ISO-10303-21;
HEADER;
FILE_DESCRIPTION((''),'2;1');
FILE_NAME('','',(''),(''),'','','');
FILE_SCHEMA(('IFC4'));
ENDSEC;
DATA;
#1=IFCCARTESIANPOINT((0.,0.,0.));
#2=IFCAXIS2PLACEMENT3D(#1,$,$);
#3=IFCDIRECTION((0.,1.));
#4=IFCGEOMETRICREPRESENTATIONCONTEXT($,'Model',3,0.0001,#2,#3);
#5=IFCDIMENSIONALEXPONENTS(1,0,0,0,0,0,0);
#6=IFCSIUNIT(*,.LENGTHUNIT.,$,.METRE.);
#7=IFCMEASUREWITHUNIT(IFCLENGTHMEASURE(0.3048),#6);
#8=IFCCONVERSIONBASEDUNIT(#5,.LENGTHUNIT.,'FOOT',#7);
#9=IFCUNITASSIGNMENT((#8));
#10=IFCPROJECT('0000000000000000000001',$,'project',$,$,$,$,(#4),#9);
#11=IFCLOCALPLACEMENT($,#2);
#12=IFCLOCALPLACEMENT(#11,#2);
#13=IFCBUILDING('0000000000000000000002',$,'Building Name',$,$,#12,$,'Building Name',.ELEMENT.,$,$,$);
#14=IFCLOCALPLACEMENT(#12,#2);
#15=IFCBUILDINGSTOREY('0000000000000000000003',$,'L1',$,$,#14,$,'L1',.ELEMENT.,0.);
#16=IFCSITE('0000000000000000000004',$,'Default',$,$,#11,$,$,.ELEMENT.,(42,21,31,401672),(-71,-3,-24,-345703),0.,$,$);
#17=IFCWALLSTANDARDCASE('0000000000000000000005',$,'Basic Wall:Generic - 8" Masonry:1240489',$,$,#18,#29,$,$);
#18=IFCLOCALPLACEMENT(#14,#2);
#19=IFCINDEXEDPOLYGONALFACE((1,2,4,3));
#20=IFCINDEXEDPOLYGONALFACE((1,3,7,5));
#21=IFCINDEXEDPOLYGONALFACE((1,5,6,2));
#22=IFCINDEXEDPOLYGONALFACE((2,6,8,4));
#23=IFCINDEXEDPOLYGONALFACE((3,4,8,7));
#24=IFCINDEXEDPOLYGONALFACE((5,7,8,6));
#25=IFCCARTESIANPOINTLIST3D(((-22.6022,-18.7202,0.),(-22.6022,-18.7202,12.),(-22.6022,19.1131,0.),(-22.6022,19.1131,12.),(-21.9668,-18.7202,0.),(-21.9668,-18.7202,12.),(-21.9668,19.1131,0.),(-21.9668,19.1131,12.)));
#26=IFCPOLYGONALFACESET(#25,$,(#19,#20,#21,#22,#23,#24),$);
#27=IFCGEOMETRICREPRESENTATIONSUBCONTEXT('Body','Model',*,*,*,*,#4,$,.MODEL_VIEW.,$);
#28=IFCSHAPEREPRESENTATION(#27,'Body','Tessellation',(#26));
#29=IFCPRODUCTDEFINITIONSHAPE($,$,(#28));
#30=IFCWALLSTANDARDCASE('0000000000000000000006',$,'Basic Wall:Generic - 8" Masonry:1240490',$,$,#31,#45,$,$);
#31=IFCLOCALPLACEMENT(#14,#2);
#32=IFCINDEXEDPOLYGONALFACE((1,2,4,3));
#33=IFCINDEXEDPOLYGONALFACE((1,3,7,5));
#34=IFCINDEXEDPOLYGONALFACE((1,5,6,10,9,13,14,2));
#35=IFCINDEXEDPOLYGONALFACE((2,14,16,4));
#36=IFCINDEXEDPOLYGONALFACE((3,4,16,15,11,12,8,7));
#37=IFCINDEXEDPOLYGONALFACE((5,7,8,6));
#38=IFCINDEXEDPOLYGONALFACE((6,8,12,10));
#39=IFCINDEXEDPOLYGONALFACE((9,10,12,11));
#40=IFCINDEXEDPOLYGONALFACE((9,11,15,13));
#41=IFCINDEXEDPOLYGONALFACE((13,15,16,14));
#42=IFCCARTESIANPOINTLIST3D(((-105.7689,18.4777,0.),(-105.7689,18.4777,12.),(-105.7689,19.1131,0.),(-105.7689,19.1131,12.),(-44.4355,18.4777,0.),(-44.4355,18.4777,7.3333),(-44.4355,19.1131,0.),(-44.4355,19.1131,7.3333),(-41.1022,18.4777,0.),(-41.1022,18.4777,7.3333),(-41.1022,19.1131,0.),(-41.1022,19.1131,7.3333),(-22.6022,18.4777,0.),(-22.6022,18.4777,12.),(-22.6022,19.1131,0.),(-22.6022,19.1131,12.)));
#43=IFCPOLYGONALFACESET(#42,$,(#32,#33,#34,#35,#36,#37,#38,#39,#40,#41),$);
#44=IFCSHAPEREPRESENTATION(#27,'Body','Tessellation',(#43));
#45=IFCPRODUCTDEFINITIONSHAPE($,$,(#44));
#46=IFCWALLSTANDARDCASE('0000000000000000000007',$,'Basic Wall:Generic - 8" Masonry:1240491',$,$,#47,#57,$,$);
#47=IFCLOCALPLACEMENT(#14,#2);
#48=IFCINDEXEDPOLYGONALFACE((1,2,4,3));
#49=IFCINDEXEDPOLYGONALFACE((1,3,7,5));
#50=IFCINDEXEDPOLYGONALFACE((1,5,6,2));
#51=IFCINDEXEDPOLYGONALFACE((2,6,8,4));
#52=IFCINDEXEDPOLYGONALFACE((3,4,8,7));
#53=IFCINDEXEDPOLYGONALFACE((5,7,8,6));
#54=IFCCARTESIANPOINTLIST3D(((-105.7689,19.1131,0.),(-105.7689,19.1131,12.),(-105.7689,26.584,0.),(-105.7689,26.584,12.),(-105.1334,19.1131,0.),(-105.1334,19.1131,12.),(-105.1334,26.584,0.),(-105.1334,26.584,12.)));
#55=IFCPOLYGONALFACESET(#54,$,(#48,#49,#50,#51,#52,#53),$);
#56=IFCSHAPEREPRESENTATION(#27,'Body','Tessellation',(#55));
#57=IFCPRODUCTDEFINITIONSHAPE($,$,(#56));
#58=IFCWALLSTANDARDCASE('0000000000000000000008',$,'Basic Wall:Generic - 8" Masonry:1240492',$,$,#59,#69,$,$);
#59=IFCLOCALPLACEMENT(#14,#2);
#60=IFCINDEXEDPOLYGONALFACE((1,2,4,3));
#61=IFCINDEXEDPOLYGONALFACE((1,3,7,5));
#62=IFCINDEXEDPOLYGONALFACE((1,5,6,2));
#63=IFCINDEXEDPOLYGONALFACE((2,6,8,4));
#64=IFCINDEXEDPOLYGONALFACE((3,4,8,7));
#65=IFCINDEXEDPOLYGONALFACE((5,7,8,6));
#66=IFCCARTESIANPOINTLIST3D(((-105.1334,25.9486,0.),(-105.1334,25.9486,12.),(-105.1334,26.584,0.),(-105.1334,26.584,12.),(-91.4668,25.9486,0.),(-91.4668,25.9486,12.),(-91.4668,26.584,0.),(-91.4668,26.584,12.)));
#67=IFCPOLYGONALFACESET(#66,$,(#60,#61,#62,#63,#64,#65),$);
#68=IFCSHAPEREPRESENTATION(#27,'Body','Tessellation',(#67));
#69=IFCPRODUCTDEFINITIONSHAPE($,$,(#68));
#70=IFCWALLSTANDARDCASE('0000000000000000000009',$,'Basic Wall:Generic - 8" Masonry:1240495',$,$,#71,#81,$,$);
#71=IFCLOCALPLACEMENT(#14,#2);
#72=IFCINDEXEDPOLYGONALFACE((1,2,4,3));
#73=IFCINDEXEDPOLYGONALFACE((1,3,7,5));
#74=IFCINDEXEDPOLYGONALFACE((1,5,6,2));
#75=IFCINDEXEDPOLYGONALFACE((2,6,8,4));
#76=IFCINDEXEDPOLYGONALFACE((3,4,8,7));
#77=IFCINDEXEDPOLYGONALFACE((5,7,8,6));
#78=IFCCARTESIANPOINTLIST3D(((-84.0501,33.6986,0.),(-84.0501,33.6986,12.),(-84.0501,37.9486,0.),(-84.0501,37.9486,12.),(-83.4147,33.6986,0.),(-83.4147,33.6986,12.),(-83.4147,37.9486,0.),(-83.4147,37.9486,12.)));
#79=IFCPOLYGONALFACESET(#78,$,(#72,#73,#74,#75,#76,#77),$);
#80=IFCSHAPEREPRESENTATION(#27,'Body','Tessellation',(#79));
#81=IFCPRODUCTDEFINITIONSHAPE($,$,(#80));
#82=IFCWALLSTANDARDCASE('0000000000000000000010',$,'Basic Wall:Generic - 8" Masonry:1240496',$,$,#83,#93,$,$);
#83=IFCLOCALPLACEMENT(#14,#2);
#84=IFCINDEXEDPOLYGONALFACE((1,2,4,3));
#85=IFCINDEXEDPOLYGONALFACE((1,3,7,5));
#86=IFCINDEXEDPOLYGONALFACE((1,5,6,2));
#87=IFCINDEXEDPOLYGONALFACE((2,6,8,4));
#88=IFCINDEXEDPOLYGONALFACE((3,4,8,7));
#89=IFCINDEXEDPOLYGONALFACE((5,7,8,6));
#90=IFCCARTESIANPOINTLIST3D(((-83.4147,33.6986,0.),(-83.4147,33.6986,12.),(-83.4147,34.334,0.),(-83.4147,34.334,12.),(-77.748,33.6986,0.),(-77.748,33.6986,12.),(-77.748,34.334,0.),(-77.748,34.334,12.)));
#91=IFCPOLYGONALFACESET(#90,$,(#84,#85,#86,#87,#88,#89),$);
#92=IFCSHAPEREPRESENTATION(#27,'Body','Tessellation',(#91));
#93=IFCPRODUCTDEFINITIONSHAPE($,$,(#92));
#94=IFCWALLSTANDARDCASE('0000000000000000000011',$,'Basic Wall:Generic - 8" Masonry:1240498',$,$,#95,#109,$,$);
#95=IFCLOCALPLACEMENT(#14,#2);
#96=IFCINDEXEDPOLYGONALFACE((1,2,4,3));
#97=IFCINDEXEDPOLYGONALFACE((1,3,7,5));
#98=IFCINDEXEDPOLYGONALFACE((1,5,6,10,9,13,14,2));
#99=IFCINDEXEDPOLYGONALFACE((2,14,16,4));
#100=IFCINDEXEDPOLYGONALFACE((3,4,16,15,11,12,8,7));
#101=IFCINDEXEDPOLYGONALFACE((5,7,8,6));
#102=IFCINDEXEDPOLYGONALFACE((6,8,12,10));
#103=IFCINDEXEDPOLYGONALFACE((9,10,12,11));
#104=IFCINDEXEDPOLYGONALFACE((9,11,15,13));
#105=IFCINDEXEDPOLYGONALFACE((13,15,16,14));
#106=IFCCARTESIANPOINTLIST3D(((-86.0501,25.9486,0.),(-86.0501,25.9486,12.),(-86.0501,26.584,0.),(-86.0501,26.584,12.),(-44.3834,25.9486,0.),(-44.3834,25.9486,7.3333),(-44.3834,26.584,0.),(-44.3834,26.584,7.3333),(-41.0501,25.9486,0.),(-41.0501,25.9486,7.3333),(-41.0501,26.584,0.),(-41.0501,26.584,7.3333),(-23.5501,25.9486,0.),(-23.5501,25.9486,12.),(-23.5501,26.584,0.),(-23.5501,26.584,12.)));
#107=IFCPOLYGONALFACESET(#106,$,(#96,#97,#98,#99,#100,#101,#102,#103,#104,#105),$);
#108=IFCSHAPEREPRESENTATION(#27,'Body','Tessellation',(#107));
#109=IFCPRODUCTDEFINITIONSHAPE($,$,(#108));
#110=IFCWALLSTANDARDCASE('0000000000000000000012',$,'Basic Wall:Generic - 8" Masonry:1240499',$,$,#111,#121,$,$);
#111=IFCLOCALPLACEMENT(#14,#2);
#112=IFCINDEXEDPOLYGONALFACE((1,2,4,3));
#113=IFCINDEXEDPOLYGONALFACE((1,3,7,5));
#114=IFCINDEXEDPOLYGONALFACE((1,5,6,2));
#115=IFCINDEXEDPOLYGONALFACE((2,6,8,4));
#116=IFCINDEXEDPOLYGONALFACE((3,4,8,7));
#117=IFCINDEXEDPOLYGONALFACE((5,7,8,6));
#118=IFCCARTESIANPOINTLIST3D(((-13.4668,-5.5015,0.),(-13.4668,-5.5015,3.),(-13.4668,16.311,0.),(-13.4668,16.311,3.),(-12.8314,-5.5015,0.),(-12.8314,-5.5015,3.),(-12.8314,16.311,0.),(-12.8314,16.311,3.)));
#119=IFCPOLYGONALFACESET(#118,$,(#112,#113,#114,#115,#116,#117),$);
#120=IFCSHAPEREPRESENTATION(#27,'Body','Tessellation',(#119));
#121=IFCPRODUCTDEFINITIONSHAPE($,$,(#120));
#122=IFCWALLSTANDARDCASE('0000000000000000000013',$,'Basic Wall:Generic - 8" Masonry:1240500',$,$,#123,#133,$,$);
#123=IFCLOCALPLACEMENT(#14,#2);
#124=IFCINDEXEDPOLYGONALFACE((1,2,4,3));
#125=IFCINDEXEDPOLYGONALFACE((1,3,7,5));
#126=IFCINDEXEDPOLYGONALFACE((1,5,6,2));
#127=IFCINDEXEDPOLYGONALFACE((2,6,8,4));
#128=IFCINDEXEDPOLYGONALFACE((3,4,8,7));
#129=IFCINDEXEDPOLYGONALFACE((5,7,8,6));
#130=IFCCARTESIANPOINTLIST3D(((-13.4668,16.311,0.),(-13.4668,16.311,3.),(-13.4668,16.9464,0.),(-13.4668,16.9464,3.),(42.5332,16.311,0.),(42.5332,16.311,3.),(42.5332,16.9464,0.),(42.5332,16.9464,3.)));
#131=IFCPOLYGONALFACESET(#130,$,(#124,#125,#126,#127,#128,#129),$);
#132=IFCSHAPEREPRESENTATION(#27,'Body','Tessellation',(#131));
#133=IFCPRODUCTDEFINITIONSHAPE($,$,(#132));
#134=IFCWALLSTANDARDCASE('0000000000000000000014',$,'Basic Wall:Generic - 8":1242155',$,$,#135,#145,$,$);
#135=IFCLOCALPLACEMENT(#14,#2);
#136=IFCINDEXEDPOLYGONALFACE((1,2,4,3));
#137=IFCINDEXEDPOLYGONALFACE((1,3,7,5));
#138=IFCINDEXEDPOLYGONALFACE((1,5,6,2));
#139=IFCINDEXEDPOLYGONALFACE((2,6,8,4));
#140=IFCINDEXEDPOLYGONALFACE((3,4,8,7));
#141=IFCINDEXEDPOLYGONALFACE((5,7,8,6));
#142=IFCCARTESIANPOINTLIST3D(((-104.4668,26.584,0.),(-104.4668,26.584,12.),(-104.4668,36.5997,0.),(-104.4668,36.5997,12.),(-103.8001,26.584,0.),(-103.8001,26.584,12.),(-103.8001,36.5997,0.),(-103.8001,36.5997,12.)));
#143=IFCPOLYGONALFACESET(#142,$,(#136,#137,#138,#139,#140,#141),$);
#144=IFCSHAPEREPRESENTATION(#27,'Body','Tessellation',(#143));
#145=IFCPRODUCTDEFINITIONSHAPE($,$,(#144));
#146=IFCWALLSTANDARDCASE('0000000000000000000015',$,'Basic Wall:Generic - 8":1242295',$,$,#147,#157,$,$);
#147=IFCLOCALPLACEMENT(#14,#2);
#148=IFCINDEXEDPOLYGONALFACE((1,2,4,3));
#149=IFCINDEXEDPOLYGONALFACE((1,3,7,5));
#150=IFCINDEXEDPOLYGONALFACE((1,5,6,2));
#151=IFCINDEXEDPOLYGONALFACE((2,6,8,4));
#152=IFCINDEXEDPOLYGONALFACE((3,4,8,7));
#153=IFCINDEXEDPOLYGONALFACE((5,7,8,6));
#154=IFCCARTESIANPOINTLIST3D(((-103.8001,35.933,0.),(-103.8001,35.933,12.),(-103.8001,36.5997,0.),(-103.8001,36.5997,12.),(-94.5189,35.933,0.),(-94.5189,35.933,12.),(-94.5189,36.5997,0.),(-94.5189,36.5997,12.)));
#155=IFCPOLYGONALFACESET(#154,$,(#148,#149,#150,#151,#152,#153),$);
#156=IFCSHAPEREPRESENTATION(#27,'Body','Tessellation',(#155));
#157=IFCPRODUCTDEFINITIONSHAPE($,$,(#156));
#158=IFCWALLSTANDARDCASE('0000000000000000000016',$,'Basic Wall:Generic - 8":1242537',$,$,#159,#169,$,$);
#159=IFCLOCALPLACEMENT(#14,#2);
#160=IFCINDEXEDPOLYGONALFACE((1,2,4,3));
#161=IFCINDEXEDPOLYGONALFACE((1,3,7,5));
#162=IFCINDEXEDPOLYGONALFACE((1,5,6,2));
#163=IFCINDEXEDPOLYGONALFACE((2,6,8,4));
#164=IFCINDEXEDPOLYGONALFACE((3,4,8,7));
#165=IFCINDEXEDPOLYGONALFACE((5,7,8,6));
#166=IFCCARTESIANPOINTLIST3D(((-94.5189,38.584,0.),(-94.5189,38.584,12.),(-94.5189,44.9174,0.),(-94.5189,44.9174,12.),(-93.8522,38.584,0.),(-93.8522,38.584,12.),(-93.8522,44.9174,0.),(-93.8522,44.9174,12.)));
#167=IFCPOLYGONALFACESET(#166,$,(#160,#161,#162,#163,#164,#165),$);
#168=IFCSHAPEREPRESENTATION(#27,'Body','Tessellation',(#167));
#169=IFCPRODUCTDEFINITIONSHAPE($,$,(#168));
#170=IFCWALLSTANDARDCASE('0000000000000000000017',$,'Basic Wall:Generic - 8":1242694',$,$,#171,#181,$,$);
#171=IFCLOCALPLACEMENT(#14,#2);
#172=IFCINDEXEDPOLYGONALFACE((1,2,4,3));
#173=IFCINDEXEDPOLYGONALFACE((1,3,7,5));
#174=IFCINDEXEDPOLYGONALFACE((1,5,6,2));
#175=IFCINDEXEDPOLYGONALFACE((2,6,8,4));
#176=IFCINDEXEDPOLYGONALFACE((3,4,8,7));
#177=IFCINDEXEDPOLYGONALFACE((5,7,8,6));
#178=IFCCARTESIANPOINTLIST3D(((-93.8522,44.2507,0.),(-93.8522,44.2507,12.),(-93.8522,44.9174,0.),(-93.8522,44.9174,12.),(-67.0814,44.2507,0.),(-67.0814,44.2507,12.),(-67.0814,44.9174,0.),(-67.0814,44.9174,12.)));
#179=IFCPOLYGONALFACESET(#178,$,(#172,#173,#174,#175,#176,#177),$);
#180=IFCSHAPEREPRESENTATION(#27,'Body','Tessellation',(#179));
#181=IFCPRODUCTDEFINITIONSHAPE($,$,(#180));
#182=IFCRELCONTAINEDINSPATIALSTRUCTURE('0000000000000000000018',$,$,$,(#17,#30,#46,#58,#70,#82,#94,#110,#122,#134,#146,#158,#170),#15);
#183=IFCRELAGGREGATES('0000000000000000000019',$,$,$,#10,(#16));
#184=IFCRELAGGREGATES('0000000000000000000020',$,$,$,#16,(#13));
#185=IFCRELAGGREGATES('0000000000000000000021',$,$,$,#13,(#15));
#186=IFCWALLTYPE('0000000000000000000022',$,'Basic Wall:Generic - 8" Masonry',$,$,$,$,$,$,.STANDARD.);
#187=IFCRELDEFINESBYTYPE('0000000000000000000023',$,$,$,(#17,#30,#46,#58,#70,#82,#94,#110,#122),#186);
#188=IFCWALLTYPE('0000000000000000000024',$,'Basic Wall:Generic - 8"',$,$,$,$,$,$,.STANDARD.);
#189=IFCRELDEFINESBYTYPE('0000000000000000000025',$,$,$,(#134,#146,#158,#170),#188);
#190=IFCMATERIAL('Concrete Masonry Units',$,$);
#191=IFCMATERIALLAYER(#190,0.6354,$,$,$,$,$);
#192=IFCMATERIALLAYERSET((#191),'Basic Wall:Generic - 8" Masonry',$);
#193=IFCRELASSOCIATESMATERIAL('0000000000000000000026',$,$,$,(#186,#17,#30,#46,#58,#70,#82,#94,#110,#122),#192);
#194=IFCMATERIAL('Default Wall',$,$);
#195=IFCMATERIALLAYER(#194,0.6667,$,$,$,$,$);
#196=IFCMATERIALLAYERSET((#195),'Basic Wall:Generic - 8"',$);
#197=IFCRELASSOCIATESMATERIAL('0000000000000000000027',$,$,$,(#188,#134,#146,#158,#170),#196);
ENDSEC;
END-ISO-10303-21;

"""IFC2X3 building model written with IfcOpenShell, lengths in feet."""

from ifc_helpers import new_model, entity, si_unit, converted_unit, direction, frame, frame_2d, origin, place, context, subcontext, project, spatial, rectangle, extrude, material, layer, layer_set, layer_usage, type_object, element, save


model = new_model("IFC2X3")

# Units and contexts
model_context = context("Model", 3, precision=0.0001, world=origin(), true_north=direction((0.0, 1.0)))
body_context = subcontext(model_context, "Body", "Model", "MODEL_VIEW")
ifc_project = project(units=[converted_unit("LENGTHUNIT", "FOOT", entity("IfcLengthMeasure", 0.3048), si_unit("LENGTHUNIT", "METRE"), dimensions=[1, 0, 0, 0, 0, 0, 0])], contexts=[model_context])

# Site, building, storey
site_placement = place(None, origin())
site = spatial("IfcSite", under=ifc_project, at=site_placement, Name="Default", CompositionType="ELEMENT", RefLatitude=(42, 21, 31, 401672), RefLongitude=(-71, -3, -24, -345703), RefElevation=0.0)
building_placement = place(site_placement, origin())
building = spatial("IfcBuilding", under=site, at=building_placement, Name="Building Name", LongName="Building Name", CompositionType="ELEMENT")
storey_placement = place(building_placement, origin())
storey = spatial("IfcBuildingStorey", under=building, at=storey_placement, Name="L1", LongName="L1", CompositionType="ELEMENT", Elevation=0.0)

# Wall
ifc_material_1 = material(Name="Concrete Masonry Units")
ifc_layer_1 = layer(ifc_material_1, 0.6354)
ifc_layer_set_1 = layer_set([ifc_layer_1], Name="Basic Wall:Generic - 8\" Masonry")
ifc_layer_usage_1 = layer_usage(ifc_layer_set_1, "AXIS2", "NEGATIVE", 0.3177)
wall_type_1 = type_object("IfcWallType", Name="Basic Wall:Generic - 8\" Masonry", PredefinedType="STANDARD", material=ifc_layer_set_1)
wall_1_placement = place(storey_placement, frame((-22.2845, 19.1131, 0.0), z_axis=(0.0, 0.0, 1.0), x_axis=(0.0, -1.0, 0.0)))
element("IfcWallStandardCase", 1, at=wall_1_placement, inside=storey, type_object=wall_type_1, material=ifc_layer_usage_1, Name="Basic Wall:Generic - 8\" Masonry:1240489", context=body_context, shape_type="SweptSolid", body=[
    extrude(rectangle(XDim=37.8333, YDim=0.6354, at=frame_2d((18.9167, 0.0), x_axis=(-1.0, 0.0))), origin(), (0.0, 0.0, 1.0), 12.0),
])

# Wall, opening
ifc_layer_usage_2 = layer_usage(ifc_layer_set_1, "AXIS2", "NEGATIVE", 0.3177)
wall_2_placement = place(storey_placement, frame((-22.6022, 18.7954, 0.0), z_axis=(0.0, 0.0, 1.0), x_axis=(-1.0, 0.0, 0.0)))
wall_2 = element("IfcWallStandardCase", 2, at=wall_2_placement, inside=storey, type_object=wall_type_1, material=ifc_layer_usage_2, Name="Basic Wall:Generic - 8\" Masonry:1240490", context=body_context, shape_type="SweptSolid", body=[
    extrude(rectangle(XDim=83.1667, YDim=0.6354, at=frame_2d((41.5833, 0.0), x_axis=(1.0, 0.0))), origin(), (0.0, 0.0, 1.0), 12.0),
])
opening_1_placement = place(wall_2_placement, frame((18.5, -0.3177, 0.0)))
element("IfcOpeningElement", 3, at=opening_1_placement, cuts=wall_2, ObjectType="Opening", context=body_context, shape_type="SweptSolid", body=[
    extrude(rectangle(XDim=7.3333, YDim=3.3333, at=frame_2d((3.6667, 1.6667), x_axis=(1.0, 0.0))), frame((0.0, 0.0, 0.0), z_axis=(0.0, 1.0, 0.0), x_axis=(0.0, 0.0, 1.0)), (0.0, 0.0, 1.0), 0.6354),
])

# Walls
ifc_layer_usage_3 = layer_usage(ifc_layer_set_1, "AXIS2", "NEGATIVE", 0.3177)
wall_3_placement = place(storey_placement, frame((-105.4511, 19.1131, 0.0), z_axis=(0.0, 0.0, 1.0), x_axis=(0.0, 1.0, 0.0)))
element("IfcWallStandardCase", 4, at=wall_3_placement, inside=storey, type_object=wall_type_1, material=ifc_layer_usage_3, Name="Basic Wall:Generic - 8\" Masonry:1240491", context=body_context, shape_type="SweptSolid", body=[
    extrude(rectangle(XDim=7.4709, YDim=0.6354, at=frame_2d((3.7355, 0.0), x_axis=(-1.0, 0.0))), origin(), (0.0, 0.0, 1.0), 12.0),
])
ifc_layer_usage_4 = layer_usage(ifc_layer_set_1, "AXIS2", "NEGATIVE", 0.3177)
wall_4_placement = place(storey_placement, frame((-105.1334, 26.2663, 0.0)))
element("IfcWallStandardCase", 5, at=wall_4_placement, inside=storey, type_object=wall_type_1, material=ifc_layer_usage_4, Name="Basic Wall:Generic - 8\" Masonry:1240492", context=body_context, shape_type="SweptSolid", body=[
    extrude(rectangle(XDim=13.6667, YDim=0.6354, at=frame_2d((6.8333, 0.0), x_axis=(-1.0, 0.0))), origin(), (0.0, 0.0, 1.0), 12.0),
])

# Walls
ifc_layer_usage_5 = layer_usage(ifc_layer_set_1, "AXIS2", "NEGATIVE", 0.3177)
wall_5_placement = place(storey_placement, frame((-83.7324, 37.9486, 0.0), z_axis=(0.0, 0.0, 1.0), x_axis=(0.0, -1.0, 0.0)))
element("IfcWallStandardCase", 6, at=wall_5_placement, inside=storey, type_object=wall_type_1, material=ifc_layer_usage_5, Name="Basic Wall:Generic - 8\" Masonry:1240495", context=body_context, shape_type="SweptSolid", body=[
    extrude(rectangle(XDim=4.25, YDim=0.6354, at=frame_2d((2.125, 0.0), x_axis=(-1.0, 0.0))), origin(), (0.0, 0.0, 1.0), 12.0),
])
ifc_layer_usage_6 = layer_usage(ifc_layer_set_1, "AXIS2", "NEGATIVE", 0.3177)
wall_6_placement = place(storey_placement, frame((-83.4147, 34.0163, 0.0)))
element("IfcWallStandardCase", 7, at=wall_6_placement, inside=storey, type_object=wall_type_1, material=ifc_layer_usage_6, Name="Basic Wall:Generic - 8\" Masonry:1240496", context=body_context, shape_type="SweptSolid", body=[
    extrude(rectangle(XDim=5.6667, YDim=0.6354, at=frame_2d((2.8333, 0.0), x_axis=(-1.0, 0.0))), origin(), (0.0, 0.0, 1.0), 12.0),
])

# Wall, opening
ifc_layer_usage_7 = layer_usage(ifc_layer_set_1, "AXIS2", "NEGATIVE", 0.3177)
wall_7_placement = place(storey_placement, frame((-23.5501, 26.2663, 0.0), z_axis=(0.0, 0.0, 1.0), x_axis=(-1.0, 0.0, 0.0)))
wall_7 = element("IfcWallStandardCase", 8, at=wall_7_placement, inside=storey, type_object=wall_type_1, material=ifc_layer_usage_7, Name="Basic Wall:Generic - 8\" Masonry:1240498", context=body_context, shape_type="SweptSolid", body=[
    extrude(rectangle(XDim=62.5, YDim=0.6354, at=frame_2d((31.25, 0.0), x_axis=(1.0, 0.0))), origin(), (0.0, 0.0, 1.0), 12.0),
])
opening_2_placement = place(wall_7_placement, frame((20.8333, 0.3177, 0.0)))
element("IfcOpeningElement", 9, at=opening_2_placement, cuts=wall_7, ObjectType="Opening", context=body_context, shape_type="SweptSolid", body=[
    extrude(rectangle(XDim=7.3333, YDim=3.3333, at=frame_2d((3.6667, 1.6667), x_axis=(1.0, 0.0))), frame((0.0, 0.0, 0.0), z_axis=(0.0, -1.0, 0.0), x_axis=(0.0, 0.0, 1.0)), (0.0, 0.0, 1.0), 0.6354),
])

# Walls
ifc_layer_usage_8 = layer_usage(ifc_layer_set_1, "AXIS2", "NEGATIVE", 0.3177)
wall_8_placement = place(storey_placement, frame((-13.1491, -5.5015, 0.0), z_axis=(0.0, 0.0, 1.0), x_axis=(0.0, 1.0, 0.0)))
element("IfcWallStandardCase", 10, at=wall_8_placement, inside=storey, type_object=wall_type_1, material=ifc_layer_usage_8, Name="Basic Wall:Generic - 8\" Masonry:1240499", context=body_context, shape_type="SweptSolid", body=[
    extrude(rectangle(XDim=21.8125, YDim=0.6354, at=frame_2d((10.9063, 0.0), x_axis=(-1.0, 0.0))), origin(), (0.0, 0.0, 1.0), 3.0),
])
ifc_layer_usage_9 = layer_usage(ifc_layer_set_1, "AXIS2", "NEGATIVE", 0.3177)
wall_9_placement = place(storey_placement, frame((-13.4668, 16.6287, 0.0)))
element("IfcWallStandardCase", 11, at=wall_9_placement, inside=storey, type_object=wall_type_1, material=ifc_layer_usage_9, Name="Basic Wall:Generic - 8\" Masonry:1240500", context=body_context, shape_type="SweptSolid", body=[
    extrude(rectangle(XDim=56.0, YDim=0.6354, at=frame_2d((28.0, 0.0), x_axis=(-1.0, 0.0))), origin(), (0.0, 0.0, 1.0), 3.0),
])
ifc_material_2 = material(Name="Default Wall")
ifc_layer_2 = layer(ifc_material_2, 0.6667)
ifc_layer_set_2 = layer_set([ifc_layer_2], Name="Basic Wall:Generic - 8\"")
ifc_layer_usage_10 = layer_usage(ifc_layer_set_2, "AXIS2", "NEGATIVE", 0.3333)
wall_type_2 = type_object("IfcWallType", Name="Basic Wall:Generic - 8\"", PredefinedType="STANDARD", material=ifc_layer_set_2)
wall_10_placement = place(storey_placement, frame((-104.1334, 26.584, 0.0), z_axis=(0.0, 0.0, 1.0), x_axis=(0.0, 1.0, 0.0)))
element("IfcWallStandardCase", 12, at=wall_10_placement, inside=storey, type_object=wall_type_2, material=ifc_layer_usage_10, Name="Basic Wall:Generic - 8\":1242155", context=body_context, shape_type="SweptSolid", body=[
    extrude(rectangle(XDim=10.0156, YDim=0.6667, at=frame_2d((5.0078, 0.0), x_axis=(-1.0, 0.0))), origin(), (0.0, 0.0, 1.0), 12.0),
])
ifc_layer_usage_11 = layer_usage(ifc_layer_set_2, "AXIS2", "POSITIVE", -0.3333)
wall_11_placement = place(storey_placement, frame((-103.8001, 36.2663, 0.0)))
element("IfcWallStandardCase", 13, at=wall_11_placement, inside=storey, type_object=wall_type_2, material=ifc_layer_usage_11, Name="Basic Wall:Generic - 8\":1242295", context=body_context, shape_type="SweptSolid", body=[
    extrude(rectangle(XDim=9.2812, YDim=0.6667, at=frame_2d((4.6406, 0.0), x_axis=(-1.0, 0.0))), origin(), (0.0, 0.0, 1.0), 12.0),
])
ifc_layer_usage_12 = layer_usage(ifc_layer_set_2, "AXIS2", "NEGATIVE", 0.3333)
wall_12_placement = place(storey_placement, frame((-94.1855, 38.584, 0.0), z_axis=(0.0, 0.0, 1.0), x_axis=(0.0, 1.0, 0.0)))
element("IfcWallStandardCase", 14, at=wall_12_placement, inside=storey, type_object=wall_type_2, material=ifc_layer_usage_12, Name="Basic Wall:Generic - 8\":1242537", context=body_context, shape_type="SweptSolid", body=[
    extrude(rectangle(XDim=6.3333, YDim=0.6667, at=frame_2d((3.1667, 0.0), x_axis=(-1.0, 0.0))), origin(), (0.0, 0.0, 1.0), 12.0),
])
ifc_layer_usage_13 = layer_usage(ifc_layer_set_2, "AXIS2", "POSITIVE", -0.3333)
wall_13_placement = place(storey_placement, frame((-93.8522, 44.584, 0.0)))
element("IfcWallStandardCase", 15, at=wall_13_placement, inside=storey, type_object=wall_type_2, material=ifc_layer_usage_13, Name="Basic Wall:Generic - 8\":1242694", context=body_context, shape_type="SweptSolid", body=[
    extrude(rectangle(XDim=26.7708, YDim=0.6667, at=frame_2d((13.3854, 0.0), x_axis=(-1.0, 0.0))), origin(), (0.0, 0.0, 1.0), 12.0),
])

save(model, "model.ifc")
